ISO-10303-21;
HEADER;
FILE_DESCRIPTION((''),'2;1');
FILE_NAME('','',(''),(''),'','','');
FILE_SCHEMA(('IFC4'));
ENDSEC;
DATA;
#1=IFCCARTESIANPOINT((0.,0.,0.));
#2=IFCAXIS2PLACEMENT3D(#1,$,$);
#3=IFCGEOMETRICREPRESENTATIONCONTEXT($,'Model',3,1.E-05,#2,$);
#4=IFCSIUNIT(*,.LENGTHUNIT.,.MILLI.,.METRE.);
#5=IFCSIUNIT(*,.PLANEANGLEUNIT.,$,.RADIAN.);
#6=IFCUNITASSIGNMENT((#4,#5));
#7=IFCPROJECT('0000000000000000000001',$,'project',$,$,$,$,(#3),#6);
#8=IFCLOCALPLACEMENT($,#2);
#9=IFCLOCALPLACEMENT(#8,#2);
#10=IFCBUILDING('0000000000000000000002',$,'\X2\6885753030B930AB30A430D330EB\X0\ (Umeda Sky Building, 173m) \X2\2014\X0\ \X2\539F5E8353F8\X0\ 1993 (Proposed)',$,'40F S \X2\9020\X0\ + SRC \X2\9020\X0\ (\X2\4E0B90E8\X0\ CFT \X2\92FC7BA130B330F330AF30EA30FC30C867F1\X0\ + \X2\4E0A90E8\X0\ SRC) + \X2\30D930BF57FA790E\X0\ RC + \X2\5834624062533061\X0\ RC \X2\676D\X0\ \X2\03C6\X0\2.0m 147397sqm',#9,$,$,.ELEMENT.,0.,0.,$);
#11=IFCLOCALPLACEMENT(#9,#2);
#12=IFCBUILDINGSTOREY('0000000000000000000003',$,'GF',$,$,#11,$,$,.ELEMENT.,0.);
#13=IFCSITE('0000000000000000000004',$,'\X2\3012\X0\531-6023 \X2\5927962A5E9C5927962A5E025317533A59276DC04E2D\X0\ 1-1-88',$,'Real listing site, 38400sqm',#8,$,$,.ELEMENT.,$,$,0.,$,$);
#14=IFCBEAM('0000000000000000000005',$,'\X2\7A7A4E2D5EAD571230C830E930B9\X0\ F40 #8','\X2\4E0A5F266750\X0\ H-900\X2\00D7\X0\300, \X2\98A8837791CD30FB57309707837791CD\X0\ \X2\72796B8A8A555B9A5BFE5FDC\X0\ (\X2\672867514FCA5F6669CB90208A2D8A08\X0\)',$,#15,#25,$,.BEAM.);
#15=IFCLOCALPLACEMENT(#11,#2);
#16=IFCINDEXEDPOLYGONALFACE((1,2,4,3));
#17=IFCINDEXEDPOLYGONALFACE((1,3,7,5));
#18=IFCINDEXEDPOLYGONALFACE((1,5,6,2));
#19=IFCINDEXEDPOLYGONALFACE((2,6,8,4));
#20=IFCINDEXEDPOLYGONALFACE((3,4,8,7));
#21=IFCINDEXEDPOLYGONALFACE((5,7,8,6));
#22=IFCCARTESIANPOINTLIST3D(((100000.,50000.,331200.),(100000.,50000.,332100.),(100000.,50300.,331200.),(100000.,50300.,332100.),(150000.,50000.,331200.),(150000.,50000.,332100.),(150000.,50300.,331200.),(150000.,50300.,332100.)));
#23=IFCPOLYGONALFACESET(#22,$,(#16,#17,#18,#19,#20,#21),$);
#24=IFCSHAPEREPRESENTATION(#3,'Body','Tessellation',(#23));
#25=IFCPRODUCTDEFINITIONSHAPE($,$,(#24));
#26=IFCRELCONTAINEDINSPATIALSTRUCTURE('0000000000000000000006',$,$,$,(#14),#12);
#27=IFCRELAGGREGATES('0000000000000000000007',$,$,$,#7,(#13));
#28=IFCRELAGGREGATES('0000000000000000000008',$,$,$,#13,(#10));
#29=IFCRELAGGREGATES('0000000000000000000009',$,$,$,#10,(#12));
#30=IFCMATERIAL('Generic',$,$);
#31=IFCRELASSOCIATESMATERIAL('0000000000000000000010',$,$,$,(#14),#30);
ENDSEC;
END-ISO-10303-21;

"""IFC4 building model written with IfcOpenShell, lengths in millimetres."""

from ifc_helpers import new_model, si_unit, frame, frame_2d, origin, place, context, project, spatial, rectangle, extrude, material, element, save


model = new_model("IFC4")

# Units and contexts
model_context = context("Model", 3, precision=1e-05, world=origin())
ifc_project = project(units=[si_unit("LENGTHUNIT", "METRE", prefix="MILLI"), si_unit("PLANEANGLEUNIT", "RADIAN")], contexts=[model_context])

# Site, building, storey
site_placement = place(None, origin())
site = spatial("IfcSite", under=ifc_project, at=site_placement, Name="〒531-6023 大阪府大阪市北区大淀中 1-1-88", ObjectType="Real listing site, 38400sqm", CompositionType="ELEMENT", RefElevation=0.0)
building_placement = place(site_placement, origin())
building = spatial("IfcBuilding", under=site, at=building_placement, Name="梅田スカイビル (Umeda Sky Building, 173m) — 原広司 1993 (Proposed)", ObjectType="40F S 造 + SRC 造 (下部 CFT 鋼管コンクリート柱 + 上部 SRC) + ベタ基礎 RC + 場所打ち RC 杭 φ2.0m 147397sqm", CompositionType="ELEMENT", ElevationOfRefHeight=0.0, ElevationOfTerrain=0.0)
storey_placement = place(building_placement, origin())
storey = spatial("IfcBuildingStorey", under=building, at=storey_placement, Name="GF", CompositionType="ELEMENT", Elevation=0.0)

# Beam
ifc_material_1 = material(Name="Generic")
beam_1_placement = place(storey_placement, frame((50000.0, 25000.0, 165600.0)))
element("IfcBeam", 1, at=beam_1_placement, inside=storey, material=ifc_material_1, Name="空中庭園トラス F40 #8", Description="上弦材 H-900×300, 風荷重・地震荷重 特殊評定対応 (木村俊彦構造設計)", PredefinedType="BEAM", context=model_context, shape_type="SweptSolid", body=[
    extrude(rectangle(XDim=50000.0, YDim=300.0, at=frame_2d((25000.0, 150.0))), frame((50000.0, 25000.0, 165600.0)), (0.0, 0.0, 1.0), 900.0),
])

save(model, "model.ifc")
